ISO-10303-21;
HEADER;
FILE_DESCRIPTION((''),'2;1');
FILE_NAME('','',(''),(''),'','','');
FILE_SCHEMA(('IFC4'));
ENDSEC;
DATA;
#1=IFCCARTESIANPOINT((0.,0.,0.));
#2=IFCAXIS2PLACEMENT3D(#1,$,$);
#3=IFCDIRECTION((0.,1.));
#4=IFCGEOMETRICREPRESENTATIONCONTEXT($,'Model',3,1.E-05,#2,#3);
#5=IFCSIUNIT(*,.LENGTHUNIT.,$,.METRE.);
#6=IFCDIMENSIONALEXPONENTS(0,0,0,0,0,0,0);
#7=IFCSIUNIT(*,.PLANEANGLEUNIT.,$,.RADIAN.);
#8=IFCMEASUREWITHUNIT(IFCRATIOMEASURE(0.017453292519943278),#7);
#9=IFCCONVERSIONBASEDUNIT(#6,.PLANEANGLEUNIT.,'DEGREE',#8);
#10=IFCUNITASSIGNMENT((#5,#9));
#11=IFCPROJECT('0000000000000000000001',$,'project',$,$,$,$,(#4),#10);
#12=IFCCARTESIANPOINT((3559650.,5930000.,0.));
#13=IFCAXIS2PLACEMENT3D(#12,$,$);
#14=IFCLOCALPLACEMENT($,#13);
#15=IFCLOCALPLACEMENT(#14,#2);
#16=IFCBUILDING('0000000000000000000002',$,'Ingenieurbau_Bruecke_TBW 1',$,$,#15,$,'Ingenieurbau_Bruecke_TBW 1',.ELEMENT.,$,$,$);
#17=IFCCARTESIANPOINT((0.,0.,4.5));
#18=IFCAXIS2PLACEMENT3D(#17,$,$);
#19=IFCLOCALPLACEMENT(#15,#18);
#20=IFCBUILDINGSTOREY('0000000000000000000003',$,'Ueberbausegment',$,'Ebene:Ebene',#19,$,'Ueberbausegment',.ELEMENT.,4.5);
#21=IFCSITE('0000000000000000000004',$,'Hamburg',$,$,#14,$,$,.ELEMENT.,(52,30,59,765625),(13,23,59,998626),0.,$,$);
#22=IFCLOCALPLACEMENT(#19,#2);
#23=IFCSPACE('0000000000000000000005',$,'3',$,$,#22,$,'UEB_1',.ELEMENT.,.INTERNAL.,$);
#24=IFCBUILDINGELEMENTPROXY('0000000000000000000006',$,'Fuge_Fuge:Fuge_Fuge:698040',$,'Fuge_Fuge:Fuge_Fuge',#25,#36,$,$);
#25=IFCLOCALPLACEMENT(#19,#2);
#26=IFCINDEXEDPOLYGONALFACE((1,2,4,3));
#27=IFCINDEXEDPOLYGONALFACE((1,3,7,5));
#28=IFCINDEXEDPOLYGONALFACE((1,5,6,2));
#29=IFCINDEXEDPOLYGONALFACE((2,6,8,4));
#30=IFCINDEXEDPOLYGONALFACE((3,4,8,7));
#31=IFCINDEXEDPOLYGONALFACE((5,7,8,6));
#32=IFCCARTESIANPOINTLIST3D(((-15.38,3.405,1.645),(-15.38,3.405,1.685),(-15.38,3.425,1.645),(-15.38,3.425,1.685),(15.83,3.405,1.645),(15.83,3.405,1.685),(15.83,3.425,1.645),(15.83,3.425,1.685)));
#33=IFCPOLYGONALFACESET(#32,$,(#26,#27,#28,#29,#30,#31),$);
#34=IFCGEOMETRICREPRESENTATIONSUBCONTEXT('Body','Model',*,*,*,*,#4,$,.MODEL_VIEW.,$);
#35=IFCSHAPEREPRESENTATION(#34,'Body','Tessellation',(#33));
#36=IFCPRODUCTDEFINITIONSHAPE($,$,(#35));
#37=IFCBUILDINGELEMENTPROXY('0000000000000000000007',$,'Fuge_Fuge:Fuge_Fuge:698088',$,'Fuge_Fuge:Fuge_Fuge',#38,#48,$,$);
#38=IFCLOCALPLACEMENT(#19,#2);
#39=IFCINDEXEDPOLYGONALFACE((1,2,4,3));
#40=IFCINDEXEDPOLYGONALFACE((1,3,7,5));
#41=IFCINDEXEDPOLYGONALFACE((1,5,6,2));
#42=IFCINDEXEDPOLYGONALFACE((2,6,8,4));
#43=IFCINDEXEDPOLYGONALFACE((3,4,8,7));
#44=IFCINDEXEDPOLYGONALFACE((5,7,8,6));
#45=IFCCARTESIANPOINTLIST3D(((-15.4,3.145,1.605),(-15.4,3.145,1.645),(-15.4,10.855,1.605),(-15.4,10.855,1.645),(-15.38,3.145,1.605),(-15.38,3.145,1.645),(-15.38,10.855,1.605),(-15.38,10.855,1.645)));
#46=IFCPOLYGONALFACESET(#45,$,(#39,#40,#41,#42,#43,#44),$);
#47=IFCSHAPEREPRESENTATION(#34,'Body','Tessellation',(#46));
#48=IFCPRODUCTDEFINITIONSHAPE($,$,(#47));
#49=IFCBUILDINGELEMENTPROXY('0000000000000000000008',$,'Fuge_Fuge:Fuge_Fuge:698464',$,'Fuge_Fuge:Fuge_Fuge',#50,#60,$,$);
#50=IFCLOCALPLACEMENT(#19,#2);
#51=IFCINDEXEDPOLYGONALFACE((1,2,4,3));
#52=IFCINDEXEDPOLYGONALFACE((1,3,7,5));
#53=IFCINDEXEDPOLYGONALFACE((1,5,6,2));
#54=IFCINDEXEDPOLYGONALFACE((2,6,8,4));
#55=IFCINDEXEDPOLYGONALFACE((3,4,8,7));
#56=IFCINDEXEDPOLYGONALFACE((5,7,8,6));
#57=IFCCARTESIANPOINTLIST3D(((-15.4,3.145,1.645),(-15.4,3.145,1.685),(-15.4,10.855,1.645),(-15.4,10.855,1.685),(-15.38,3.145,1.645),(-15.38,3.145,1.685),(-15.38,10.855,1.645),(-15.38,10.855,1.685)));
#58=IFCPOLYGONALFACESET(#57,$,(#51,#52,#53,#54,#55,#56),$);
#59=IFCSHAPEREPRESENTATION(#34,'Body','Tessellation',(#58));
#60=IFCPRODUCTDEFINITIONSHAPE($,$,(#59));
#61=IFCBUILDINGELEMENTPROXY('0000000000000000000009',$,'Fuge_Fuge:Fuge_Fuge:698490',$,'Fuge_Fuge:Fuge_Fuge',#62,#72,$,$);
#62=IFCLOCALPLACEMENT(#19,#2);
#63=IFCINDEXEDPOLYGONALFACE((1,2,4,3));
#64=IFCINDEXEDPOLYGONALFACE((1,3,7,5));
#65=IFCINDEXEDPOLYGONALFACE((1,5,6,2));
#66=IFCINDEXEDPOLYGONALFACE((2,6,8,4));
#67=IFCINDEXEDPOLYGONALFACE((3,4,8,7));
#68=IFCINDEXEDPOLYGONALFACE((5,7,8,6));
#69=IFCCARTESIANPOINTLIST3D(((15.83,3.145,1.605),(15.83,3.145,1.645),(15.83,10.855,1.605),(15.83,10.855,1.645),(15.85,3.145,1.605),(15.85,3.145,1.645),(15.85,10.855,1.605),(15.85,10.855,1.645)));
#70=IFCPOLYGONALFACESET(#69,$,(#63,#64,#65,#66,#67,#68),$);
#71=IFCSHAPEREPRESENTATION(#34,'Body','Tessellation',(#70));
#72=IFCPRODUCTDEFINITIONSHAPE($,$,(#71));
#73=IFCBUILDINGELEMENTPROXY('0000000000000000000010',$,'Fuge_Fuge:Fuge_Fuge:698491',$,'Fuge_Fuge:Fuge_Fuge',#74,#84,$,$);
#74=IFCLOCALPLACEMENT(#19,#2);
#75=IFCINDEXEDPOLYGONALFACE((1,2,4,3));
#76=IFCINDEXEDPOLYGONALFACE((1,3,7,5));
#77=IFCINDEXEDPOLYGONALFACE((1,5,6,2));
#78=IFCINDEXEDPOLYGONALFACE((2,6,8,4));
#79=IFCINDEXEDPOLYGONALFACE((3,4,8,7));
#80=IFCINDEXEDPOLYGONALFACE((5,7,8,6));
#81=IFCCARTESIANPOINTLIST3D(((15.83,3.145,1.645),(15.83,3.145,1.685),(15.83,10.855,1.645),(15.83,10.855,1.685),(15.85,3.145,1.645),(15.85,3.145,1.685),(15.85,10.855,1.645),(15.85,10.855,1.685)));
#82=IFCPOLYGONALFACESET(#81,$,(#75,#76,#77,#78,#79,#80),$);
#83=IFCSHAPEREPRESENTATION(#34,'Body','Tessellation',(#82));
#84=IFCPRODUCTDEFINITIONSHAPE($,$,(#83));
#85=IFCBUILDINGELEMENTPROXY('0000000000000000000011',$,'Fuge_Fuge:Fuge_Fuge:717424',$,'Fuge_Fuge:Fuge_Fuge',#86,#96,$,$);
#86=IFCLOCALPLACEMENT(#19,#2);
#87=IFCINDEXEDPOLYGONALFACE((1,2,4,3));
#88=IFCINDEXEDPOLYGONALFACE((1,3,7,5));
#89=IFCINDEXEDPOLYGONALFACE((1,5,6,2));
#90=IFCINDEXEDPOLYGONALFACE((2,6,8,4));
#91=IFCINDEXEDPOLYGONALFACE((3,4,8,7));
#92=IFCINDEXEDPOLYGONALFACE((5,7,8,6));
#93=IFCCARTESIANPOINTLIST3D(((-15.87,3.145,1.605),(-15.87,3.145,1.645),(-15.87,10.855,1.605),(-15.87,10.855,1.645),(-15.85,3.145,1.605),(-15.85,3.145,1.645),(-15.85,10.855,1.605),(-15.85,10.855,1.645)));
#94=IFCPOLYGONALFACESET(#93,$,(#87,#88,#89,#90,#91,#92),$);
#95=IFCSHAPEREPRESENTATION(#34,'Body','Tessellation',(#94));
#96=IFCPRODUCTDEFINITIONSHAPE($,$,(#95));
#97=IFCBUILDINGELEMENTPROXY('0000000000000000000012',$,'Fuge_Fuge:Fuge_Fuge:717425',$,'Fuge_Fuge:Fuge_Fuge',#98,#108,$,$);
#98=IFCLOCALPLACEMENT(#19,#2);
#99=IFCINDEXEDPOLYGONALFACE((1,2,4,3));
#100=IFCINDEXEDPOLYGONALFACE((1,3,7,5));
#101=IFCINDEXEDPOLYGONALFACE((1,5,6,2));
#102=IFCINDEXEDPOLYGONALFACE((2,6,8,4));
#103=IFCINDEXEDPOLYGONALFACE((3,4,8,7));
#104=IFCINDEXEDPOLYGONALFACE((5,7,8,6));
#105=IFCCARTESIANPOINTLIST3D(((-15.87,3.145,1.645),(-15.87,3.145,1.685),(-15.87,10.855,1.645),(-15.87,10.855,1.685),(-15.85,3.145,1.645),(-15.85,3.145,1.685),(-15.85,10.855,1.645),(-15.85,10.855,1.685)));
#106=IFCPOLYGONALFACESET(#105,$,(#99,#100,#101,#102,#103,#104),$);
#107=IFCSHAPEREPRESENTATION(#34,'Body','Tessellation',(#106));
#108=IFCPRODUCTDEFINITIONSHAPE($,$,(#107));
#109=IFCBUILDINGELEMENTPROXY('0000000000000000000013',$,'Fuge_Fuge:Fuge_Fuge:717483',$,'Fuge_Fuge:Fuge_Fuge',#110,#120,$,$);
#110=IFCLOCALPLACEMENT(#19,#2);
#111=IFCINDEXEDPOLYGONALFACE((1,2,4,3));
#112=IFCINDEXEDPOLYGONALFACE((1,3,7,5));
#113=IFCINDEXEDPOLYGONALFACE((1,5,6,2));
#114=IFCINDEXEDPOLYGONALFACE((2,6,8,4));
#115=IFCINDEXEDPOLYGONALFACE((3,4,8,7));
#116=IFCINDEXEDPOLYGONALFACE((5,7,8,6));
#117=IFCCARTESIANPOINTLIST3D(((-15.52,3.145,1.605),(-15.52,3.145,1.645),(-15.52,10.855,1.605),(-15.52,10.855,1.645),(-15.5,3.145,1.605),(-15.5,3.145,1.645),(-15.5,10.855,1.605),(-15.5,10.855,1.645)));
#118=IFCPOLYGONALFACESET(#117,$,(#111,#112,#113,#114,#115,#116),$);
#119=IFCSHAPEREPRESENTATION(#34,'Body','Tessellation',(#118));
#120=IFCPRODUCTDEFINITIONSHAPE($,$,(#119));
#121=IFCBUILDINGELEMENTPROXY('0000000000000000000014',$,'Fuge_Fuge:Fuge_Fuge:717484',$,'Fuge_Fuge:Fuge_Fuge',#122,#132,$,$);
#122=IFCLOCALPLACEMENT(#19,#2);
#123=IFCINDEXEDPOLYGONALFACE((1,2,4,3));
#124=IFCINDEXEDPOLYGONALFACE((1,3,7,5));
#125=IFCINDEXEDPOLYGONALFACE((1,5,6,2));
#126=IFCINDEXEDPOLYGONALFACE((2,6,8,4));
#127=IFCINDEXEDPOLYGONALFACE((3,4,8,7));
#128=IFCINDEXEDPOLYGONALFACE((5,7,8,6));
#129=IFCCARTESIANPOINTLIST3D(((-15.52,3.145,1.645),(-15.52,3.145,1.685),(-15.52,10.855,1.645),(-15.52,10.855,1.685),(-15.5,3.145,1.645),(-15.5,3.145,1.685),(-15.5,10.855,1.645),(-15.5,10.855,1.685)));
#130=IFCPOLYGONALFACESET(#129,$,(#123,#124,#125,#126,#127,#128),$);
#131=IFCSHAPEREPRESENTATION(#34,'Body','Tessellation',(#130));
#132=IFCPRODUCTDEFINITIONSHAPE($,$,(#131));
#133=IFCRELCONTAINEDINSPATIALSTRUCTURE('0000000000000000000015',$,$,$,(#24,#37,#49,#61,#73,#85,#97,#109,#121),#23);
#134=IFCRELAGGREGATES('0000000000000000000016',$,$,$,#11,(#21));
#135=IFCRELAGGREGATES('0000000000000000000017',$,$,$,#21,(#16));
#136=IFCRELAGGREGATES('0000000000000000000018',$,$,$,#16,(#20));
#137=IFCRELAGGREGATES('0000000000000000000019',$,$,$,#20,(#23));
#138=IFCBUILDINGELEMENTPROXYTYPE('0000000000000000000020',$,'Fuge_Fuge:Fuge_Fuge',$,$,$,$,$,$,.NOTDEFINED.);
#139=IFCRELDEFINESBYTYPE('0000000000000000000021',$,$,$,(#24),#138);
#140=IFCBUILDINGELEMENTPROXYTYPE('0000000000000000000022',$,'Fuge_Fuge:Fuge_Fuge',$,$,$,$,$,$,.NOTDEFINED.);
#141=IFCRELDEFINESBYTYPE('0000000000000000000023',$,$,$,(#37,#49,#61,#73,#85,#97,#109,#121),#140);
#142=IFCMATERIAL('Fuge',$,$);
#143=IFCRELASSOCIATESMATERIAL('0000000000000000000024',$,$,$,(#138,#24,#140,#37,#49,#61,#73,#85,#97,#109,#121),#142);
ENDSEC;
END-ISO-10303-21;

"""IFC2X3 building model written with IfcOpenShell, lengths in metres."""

from ifc_helpers import new_model, entity, si_unit, converted_unit, direction, frame, frame_2d, origin, place, context, subcontext, project, spatial, rectangle, extrude, source, transform, mapped, material, type_object, type_shapes, element, save


model = new_model("IFC2X3")

# Units and contexts
model_context = context("Model", 3, precision=1e-05, world=origin(), true_north=direction((0.0, 1.0)))
body_context = subcontext(model_context, "Body", "Model", "MODEL_VIEW")
ifc_project = project(units=[si_unit("LENGTHUNIT", "METRE"), converted_unit("PLANEANGLEUNIT", "DEGREE", entity("IfcRatioMeasure", 0.017453292519943278), si_unit("PLANEANGLEUNIT", "RADIAN"), dimensions=[0, 0, 0, 0, 0, 0, 0])], contexts=[model_context])

# Site, building, storey, space
site_placement = place(None, frame((3559650.0, 5930000.0, 0.0)))
site = spatial("IfcSite", under=ifc_project, at=site_placement, Name="Hamburg", CompositionType="ELEMENT", RefLatitude=(52, 30, 59, 765625), RefLongitude=(13, 23, 59, 998626), RefElevation=0.0)
building_placement = place(site_placement, origin())
building = spatial("IfcBuilding", under=site, at=building_placement, Name="Ingenieurbau_Bruecke_TBW 1", LongName="Ingenieurbau_Bruecke_TBW 1", CompositionType="ELEMENT")
storey_placement = place(building_placement, frame((0.0, 0.0, 4.5)))
storey = spatial("IfcBuildingStorey", under=building, at=storey_placement, Name="Ueberbausegment", ObjectType="Ebene:Ebene", LongName="Ueberbausegment", CompositionType="ELEMENT", Elevation=4.5)
space_placement = place(storey_placement, origin())
space = spatial("IfcSpace", under=storey, at=space_placement, Name="3", LongName="UEB_1", CompositionType="ELEMENT", InteriorOrExteriorSpace="INTERNAL")

# Building element proxies
ifc_material_1 = material(Name="Fuge")
building_element_proxy_type_1 = type_object("IfcBuildingElementProxyType", Name="Fuge_Fuge:Fuge_Fuge", PredefinedType="NOTDEFINED", material=ifc_material_1)
shared_shape_1 = source(origin(), body_context, "Body", "SweptSolid", [
    extrude(rectangle(XDim=31.21, YDim=0.02, at=frame_2d((0.0, 0.0), x_axis=(1.0, 0.0))), frame((15.605, 0.01, 0.0), z_axis=(0.0, 0.0, 1.0), x_axis=(-1.0, 0.0, 0.0)), (0.0, 0.0, 1.0), 0.04),
])
type_shapes(building_element_proxy_type_1, [shared_shape_1])
proxy_1_placement = place(space_placement, frame((-15.38, 3.405, 1.645)))
element("IfcBuildingElementProxy", 1, at=proxy_1_placement, inside=space, type_object=building_element_proxy_type_1, material=ifc_material_1, Name="Fuge_Fuge:Fuge_Fuge:698040", ObjectType="Fuge_Fuge:Fuge_Fuge", context=body_context, shape_type="MappedRepresentation", body=[
    mapped(shared_shape_1, transform((0.0, 0.0, 0.0), scale=1.0)),
])
building_element_proxy_type_2 = type_object("IfcBuildingElementProxyType", Name="Fuge_Fuge:Fuge_Fuge", PredefinedType="NOTDEFINED", material=ifc_material_1)
shared_shape_2 = source(origin(), body_context, "Body", "SweptSolid", [
    extrude(rectangle(XDim=7.71, YDim=0.02, at=frame_2d((0.0, 0.0), x_axis=(1.0, 0.0))), frame((3.855, 0.01, 0.0), z_axis=(0.0, 0.0, 1.0), x_axis=(-1.0, 0.0, 0.0)), (0.0, 0.0, 1.0), 0.04),
])
type_shapes(building_element_proxy_type_2, [shared_shape_2])
for number, where, z_axis, x_axis, name in (
    (2, (-15.38, 3.145, 1.605), (0.0, 0.0, 1.0), (0.0, 1.0, 0.0), "Fuge_Fuge:Fuge_Fuge:698088"),
    (3, (-15.38, 3.145, 1.645), (0.0, 0.0, 1.0), (0.0, 1.0, 0.0), "Fuge_Fuge:Fuge_Fuge:698464"),
    (4, (15.85, 3.145, 1.605), (0.0, 0.0, 1.0), (0.0, 1.0, 0.0), "Fuge_Fuge:Fuge_Fuge:698490"),
    (5, (15.85, 3.145, 1.645), (0.0, 0.0, 1.0), (0.0, 1.0, 0.0), "Fuge_Fuge:Fuge_Fuge:698491"),
    (6, (-15.85, 3.145, 1.605), (0.0, 0.0, 1.0), (0.0, 1.0, 0.0), "Fuge_Fuge:Fuge_Fuge:717424"),
    (7, (-15.85, 3.145, 1.645), (0.0, 0.0, 1.0), (0.0, 1.0, 0.0), "Fuge_Fuge:Fuge_Fuge:717425"),
    (8, (-15.5, 3.145, 1.605), (0.0, 0.0, 1.0), (0.0, 1.0, 0.0), "Fuge_Fuge:Fuge_Fuge:717483"),
    (9, (-15.5, 3.145, 1.645), (0.0, 0.0, 1.0), (0.0, 1.0, 0.0), "Fuge_Fuge:Fuge_Fuge:717484"),
):
    element("IfcBuildingElementProxy", number, at=place(space_placement, frame(where, z_axis=z_axis, x_axis=x_axis)), inside=space, type_object=building_element_proxy_type_2, material=ifc_material_1, Name=name, ObjectType="Fuge_Fuge:Fuge_Fuge", context=body_context, shape_type="MappedRepresentation", body=[
        mapped(shared_shape_2, transform((0.0, 0.0, 0.0), scale=1.0)),
    ])

save(model, "model.ifc")
